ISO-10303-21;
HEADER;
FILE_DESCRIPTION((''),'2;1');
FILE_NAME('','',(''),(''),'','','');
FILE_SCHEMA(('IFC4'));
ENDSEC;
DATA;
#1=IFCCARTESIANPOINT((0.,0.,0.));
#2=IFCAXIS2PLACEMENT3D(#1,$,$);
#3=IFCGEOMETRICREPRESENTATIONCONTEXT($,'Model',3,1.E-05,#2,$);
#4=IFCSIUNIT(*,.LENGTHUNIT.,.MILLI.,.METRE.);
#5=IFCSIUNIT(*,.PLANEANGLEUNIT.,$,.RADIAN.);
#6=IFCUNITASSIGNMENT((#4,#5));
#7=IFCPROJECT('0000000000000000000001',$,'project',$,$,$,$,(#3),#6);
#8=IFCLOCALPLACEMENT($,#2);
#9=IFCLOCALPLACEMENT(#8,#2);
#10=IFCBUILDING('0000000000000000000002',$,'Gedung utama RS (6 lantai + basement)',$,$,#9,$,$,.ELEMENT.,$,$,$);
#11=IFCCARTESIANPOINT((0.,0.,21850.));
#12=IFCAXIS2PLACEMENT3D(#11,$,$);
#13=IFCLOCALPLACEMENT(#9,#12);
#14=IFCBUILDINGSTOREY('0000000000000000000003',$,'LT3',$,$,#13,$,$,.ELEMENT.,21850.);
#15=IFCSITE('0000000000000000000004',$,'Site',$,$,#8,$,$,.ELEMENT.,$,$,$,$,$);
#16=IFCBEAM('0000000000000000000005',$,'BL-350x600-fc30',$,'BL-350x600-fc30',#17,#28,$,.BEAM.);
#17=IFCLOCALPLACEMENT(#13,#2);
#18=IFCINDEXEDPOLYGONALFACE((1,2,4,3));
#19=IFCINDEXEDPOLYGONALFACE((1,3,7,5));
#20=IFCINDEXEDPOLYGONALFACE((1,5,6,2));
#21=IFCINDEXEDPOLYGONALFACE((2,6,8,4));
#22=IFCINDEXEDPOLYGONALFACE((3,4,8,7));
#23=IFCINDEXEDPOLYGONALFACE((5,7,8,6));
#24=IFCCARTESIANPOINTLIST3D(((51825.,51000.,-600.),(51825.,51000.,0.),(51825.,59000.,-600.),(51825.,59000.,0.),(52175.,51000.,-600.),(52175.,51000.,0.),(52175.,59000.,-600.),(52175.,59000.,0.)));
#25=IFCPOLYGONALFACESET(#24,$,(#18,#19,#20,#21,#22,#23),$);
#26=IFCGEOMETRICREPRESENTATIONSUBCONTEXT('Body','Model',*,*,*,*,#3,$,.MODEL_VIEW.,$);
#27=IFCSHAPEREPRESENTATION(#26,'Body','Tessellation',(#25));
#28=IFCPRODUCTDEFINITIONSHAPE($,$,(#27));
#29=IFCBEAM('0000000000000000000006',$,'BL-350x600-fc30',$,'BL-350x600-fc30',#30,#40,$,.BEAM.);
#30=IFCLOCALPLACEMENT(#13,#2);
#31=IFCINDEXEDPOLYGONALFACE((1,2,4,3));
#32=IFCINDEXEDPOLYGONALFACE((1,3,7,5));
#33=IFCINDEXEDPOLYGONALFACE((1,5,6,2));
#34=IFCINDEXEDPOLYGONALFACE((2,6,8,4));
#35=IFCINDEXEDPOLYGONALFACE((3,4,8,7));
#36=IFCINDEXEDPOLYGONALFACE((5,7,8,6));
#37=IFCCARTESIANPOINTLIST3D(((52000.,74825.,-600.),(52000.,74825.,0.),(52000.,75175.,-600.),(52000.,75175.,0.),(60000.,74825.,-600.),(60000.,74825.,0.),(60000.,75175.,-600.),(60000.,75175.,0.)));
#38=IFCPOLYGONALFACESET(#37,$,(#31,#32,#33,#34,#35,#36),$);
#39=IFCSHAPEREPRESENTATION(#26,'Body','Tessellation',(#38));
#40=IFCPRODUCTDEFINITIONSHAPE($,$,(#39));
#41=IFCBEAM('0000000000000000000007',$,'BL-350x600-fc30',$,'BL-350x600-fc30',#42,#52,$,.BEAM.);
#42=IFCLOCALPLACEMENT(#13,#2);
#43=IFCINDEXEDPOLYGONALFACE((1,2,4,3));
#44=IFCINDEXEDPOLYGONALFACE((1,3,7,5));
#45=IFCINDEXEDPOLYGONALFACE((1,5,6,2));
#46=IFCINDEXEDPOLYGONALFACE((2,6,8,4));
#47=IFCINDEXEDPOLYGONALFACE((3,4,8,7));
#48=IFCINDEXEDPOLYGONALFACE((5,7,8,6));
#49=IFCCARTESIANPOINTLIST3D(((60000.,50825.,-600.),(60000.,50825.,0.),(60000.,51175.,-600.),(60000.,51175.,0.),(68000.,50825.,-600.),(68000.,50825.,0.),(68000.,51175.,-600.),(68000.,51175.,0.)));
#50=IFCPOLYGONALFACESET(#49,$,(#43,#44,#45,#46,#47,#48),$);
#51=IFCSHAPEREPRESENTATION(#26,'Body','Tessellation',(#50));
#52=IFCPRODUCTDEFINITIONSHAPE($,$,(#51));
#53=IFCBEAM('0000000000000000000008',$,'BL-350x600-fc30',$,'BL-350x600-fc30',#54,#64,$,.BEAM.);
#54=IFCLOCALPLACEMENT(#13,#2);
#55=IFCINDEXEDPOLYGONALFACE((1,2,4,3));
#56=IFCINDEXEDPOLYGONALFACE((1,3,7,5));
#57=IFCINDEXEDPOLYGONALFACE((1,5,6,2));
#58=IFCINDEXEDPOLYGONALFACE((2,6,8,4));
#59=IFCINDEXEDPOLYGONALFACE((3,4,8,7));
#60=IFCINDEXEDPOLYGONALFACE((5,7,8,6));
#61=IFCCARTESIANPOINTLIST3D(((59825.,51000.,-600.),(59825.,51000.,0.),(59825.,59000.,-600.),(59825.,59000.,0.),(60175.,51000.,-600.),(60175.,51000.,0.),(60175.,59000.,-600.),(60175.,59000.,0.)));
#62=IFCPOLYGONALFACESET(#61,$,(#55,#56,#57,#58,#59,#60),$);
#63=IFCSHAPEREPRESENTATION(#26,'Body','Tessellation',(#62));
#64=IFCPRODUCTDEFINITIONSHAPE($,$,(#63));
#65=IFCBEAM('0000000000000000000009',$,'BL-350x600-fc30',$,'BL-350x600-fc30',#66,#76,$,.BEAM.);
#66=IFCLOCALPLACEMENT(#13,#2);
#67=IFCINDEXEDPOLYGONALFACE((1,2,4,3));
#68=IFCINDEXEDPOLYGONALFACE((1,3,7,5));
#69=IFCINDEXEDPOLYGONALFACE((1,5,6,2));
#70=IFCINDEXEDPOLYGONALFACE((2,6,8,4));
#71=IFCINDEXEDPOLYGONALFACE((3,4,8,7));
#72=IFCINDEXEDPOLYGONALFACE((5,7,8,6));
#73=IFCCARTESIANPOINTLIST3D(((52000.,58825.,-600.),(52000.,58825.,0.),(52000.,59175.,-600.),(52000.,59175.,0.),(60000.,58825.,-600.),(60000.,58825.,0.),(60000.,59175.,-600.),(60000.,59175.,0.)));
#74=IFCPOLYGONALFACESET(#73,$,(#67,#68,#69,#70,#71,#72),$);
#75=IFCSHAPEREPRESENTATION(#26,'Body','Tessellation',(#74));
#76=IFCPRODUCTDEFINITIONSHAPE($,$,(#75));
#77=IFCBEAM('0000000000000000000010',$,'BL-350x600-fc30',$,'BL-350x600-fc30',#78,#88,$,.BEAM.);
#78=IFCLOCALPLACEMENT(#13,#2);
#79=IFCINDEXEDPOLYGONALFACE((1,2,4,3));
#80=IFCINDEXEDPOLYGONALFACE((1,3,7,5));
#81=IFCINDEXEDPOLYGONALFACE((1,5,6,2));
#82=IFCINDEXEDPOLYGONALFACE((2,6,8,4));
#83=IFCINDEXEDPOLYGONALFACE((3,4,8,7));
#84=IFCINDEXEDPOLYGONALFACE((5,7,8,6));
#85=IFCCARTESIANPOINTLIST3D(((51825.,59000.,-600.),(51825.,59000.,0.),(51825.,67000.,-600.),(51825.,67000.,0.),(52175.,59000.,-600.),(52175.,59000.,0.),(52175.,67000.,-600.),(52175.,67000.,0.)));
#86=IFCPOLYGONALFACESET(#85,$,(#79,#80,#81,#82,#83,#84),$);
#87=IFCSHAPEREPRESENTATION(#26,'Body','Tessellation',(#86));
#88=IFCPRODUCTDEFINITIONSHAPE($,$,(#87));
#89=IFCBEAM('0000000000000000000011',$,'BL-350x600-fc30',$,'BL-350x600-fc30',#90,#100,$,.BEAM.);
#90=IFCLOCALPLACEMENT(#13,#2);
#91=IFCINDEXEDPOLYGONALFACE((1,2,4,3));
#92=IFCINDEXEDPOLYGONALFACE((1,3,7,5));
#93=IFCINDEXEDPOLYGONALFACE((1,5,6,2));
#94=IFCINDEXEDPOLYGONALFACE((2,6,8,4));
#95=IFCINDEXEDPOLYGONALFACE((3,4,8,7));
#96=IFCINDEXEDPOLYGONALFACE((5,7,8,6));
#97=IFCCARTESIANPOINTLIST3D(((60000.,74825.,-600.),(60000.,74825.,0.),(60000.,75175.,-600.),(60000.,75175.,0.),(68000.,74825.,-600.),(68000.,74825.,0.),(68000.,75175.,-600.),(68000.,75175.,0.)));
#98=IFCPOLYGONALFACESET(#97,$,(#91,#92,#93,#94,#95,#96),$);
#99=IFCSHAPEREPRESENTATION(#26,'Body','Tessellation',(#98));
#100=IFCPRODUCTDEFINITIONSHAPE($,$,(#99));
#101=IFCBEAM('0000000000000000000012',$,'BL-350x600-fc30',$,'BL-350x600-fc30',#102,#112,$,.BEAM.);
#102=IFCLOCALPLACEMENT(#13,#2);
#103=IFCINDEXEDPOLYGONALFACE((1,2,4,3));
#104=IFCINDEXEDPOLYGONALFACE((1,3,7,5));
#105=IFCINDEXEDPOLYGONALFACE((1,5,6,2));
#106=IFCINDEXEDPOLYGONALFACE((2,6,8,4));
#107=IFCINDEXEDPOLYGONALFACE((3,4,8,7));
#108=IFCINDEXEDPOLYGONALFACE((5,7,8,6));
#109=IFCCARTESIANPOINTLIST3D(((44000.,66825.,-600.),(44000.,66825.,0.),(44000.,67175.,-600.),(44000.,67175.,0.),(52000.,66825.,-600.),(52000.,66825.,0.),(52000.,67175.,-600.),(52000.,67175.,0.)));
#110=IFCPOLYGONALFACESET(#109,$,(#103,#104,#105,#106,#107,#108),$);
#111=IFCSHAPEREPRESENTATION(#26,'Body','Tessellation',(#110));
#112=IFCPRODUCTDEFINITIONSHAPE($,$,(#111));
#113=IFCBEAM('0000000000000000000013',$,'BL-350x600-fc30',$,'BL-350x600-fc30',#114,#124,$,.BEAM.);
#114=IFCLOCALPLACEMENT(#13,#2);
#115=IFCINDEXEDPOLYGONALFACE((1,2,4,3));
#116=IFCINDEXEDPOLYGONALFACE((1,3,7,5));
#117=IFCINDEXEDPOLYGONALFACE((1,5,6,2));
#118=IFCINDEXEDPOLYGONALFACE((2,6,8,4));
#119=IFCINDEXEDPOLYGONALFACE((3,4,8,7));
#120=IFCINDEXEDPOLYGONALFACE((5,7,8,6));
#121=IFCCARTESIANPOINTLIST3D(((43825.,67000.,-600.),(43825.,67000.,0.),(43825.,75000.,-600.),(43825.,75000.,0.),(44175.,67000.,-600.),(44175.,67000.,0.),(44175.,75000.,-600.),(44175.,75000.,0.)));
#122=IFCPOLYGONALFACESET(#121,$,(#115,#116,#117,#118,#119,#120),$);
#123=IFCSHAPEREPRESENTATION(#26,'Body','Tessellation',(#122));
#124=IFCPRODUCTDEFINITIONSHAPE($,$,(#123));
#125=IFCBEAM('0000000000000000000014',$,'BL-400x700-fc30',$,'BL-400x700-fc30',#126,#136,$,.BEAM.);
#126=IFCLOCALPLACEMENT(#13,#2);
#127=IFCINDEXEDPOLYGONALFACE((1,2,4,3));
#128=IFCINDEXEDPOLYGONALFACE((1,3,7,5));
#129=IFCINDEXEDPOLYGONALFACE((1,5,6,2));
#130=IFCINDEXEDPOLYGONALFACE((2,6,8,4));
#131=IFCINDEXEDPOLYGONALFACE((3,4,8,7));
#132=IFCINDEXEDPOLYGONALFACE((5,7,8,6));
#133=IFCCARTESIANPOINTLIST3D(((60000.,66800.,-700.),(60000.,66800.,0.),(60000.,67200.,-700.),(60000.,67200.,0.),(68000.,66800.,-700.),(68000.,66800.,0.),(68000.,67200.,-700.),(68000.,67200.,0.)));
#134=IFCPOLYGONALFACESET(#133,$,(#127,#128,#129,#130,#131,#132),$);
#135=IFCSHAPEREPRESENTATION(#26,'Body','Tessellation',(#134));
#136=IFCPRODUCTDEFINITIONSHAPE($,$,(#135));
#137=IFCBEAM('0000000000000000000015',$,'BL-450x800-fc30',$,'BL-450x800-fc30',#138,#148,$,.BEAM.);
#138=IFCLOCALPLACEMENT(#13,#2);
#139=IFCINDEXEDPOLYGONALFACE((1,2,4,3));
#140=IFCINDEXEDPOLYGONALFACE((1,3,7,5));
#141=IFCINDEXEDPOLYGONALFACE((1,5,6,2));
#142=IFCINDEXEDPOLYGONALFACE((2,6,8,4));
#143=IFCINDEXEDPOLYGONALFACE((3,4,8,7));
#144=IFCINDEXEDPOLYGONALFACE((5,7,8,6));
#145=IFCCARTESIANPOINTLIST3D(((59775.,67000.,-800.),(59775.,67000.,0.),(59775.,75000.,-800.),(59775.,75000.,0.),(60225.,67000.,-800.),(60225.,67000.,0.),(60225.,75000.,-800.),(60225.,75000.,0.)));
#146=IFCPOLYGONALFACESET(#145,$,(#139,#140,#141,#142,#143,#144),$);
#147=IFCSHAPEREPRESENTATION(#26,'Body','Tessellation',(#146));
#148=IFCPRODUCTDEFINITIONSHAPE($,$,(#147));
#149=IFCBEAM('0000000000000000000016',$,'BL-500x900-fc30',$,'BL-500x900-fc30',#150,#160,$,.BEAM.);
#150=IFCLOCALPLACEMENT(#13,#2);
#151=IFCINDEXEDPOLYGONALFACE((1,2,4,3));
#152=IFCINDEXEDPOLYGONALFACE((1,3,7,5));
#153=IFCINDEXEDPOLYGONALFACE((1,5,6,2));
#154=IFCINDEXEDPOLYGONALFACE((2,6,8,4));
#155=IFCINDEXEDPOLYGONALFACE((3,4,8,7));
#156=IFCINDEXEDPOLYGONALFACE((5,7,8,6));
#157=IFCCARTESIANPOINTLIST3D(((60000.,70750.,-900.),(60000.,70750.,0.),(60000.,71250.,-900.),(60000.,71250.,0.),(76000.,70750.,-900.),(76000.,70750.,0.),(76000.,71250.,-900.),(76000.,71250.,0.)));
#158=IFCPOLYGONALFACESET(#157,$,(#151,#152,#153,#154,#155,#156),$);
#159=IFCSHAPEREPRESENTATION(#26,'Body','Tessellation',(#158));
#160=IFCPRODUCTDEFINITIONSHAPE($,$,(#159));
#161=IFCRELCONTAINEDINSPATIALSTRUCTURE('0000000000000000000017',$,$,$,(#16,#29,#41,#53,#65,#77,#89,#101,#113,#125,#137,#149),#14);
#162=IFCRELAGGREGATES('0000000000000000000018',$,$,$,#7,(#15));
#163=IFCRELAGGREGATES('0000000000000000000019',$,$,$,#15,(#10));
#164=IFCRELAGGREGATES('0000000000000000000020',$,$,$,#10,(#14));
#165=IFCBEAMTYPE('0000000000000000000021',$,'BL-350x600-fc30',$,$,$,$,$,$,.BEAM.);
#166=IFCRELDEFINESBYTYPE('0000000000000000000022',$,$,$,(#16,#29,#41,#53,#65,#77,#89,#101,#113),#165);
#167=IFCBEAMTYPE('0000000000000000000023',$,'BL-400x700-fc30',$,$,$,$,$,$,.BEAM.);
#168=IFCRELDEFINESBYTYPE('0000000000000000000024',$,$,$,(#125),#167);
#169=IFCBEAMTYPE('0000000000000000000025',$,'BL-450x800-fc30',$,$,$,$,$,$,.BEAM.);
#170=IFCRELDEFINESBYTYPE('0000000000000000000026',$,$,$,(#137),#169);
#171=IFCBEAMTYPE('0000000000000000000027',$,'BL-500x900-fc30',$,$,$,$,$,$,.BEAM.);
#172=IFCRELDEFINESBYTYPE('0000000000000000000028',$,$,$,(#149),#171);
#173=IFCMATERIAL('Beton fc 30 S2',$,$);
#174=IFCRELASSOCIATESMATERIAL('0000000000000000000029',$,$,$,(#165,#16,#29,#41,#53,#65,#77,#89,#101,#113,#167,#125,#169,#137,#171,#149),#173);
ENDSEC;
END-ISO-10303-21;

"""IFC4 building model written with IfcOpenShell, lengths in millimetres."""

from ifc_helpers import new_model, si_unit, frame, origin, origin_2d, place, context, subcontext, project, spatial, rectangle, extrude, material, material_profile, profile_set, profile_usage, type_object, element, save


model = new_model("IFC4")

# Units and contexts
model_context = context("Model", 3, precision=1e-05, world=origin())
body_context = subcontext(model_context, "Body", "Model", "MODEL_VIEW")
ifc_project = project(units=[si_unit("LENGTHUNIT", "METRE", prefix="MILLI"), si_unit("PLANEANGLEUNIT", "RADIAN")], contexts=[model_context])

# Site, building, storey
site_placement = place(None, origin())
site = spatial("IfcSite", under=ifc_project, at=site_placement, Name="Site", CompositionType="ELEMENT")
building_placement = place(site_placement, origin())
building = spatial("IfcBuilding", under=site, at=building_placement, Name="Gedung utama RS (6 lantai + basement)", CompositionType="ELEMENT")
storey_placement = place(building_placement, frame((0.0, 0.0, 21850.0)))
storey = spatial("IfcBuildingStorey", under=building, at=storey_placement, Name="LT3", CompositionType="ELEMENT", Elevation=21850.0)

# Beams
ifc_material = material(Name="Beton fc 30 S2")
ifc_material_profile_1 = material_profile(ifc_material, rectangle(XDim=350.0, YDim=600.0, at=origin_2d()), Name="BL-350x600-fc30")
ifc_profile_set_1 = profile_set([ifc_material_profile_1], Name="BL-350x600-fc30")
ifc_profile_usage_1 = profile_usage(ifc_profile_set_1, cardinal=8)
beam_type_1 = type_object("IfcBeamType", Name="BL-350x600-fc30", PredefinedType="BEAM", material=ifc_profile_set_1)
beam_1_placement = place(storey_placement, frame((52000.0, 51000.0, -300.0)))
element("IfcBeam", 1, at=beam_1_placement, inside=storey, type_object=beam_type_1, material=ifc_profile_usage_1, Name="BL-350x600-fc30", ObjectType="BL-350x600-fc30", PredefinedType="BEAM", context=body_context, shape_type="SweptSolid", body=[
    extrude(rectangle(XDim=350.0, YDim=600.0, at=origin_2d()), frame((0.0, 0.0, 0.0), z_axis=(0.0, 1.0, 0.0), x_axis=(-1.0, 0.0, 0.0)), (0.0, 0.0, 1.0), 8000.0),
])
for number, where, name in (
    (2, (52000.0, 75000.0, -300.0), "BL-350x600-fc30"),
    (3, (60000.0, 51000.0, -300.0), "BL-350x600-fc30"),
):
    element("IfcBeam", number, at=place(storey_placement, frame(where)), inside=storey, type_object=beam_type_1, material=ifc_profile_usage_1, Name=name, ObjectType="BL-350x600-fc30", PredefinedType="BEAM", context=body_context, shape_type="SweptSolid", body=[
        extrude(rectangle(XDim=350.0, YDim=600.0, at=origin_2d()), frame((0.0, 0.0, 0.0), z_axis=(1.0, 0.0, 0.0), x_axis=(0.0, 1.0, 0.0)), (0.0, 0.0, 1.0), 8000.0),
    ])
beam_2_placement = place(storey_placement, frame((60000.0, 51000.0, -300.0)))
element("IfcBeam", 4, at=beam_2_placement, inside=storey, type_object=beam_type_1, material=ifc_profile_usage_1, Name="BL-350x600-fc30", ObjectType="BL-350x600-fc30", PredefinedType="BEAM", context=body_context, shape_type="SweptSolid", body=[
    extrude(rectangle(XDim=350.0, YDim=600.0, at=origin_2d()), frame((0.0, 0.0, 0.0), z_axis=(0.0, 1.0, 0.0), x_axis=(-1.0, 0.0, 0.0)), (0.0, 0.0, 1.0), 8000.0),
])
beam_3_placement = place(storey_placement, frame((52000.0, 59000.0, -300.0)))
element("IfcBeam", 5, at=beam_3_placement, inside=storey, type_object=beam_type_1, material=ifc_profile_usage_1, Name="BL-350x600-fc30", ObjectType="BL-350x600-fc30", PredefinedType="BEAM", context=body_context, shape_type="SweptSolid", body=[
    extrude(rectangle(XDim=350.0, YDim=600.0, at=origin_2d()), frame((0.0, 0.0, 0.0), z_axis=(1.0, 0.0, 0.0), x_axis=(0.0, 1.0, 0.0)), (0.0, 0.0, 1.0), 8000.0),
])
beam_4_placement = place(storey_placement, frame((52000.0, 59000.0, -300.0)))
element("IfcBeam", 6, at=beam_4_placement, inside=storey, type_object=beam_type_1, material=ifc_profile_usage_1, Name="BL-350x600-fc30", ObjectType="BL-350x600-fc30", PredefinedType="BEAM", context=body_context, shape_type="SweptSolid", body=[
    extrude(rectangle(XDim=350.0, YDim=600.0, at=origin_2d()), frame((0.0, 0.0, 0.0), z_axis=(0.0, 1.0, 0.0), x_axis=(-1.0, 0.0, 0.0)), (0.0, 0.0, 1.0), 8000.0),
])
for number, where, name in (
    (7, (60000.0, 75000.0, -300.0), "BL-350x600-fc30"),
    (8, (44000.0, 67000.0, -300.0), "BL-350x600-fc30"),
):
    element("IfcBeam", number, at=place(storey_placement, frame(where)), inside=storey, type_object=beam_type_1, material=ifc_profile_usage_1, Name=name, ObjectType="BL-350x600-fc30", PredefinedType="BEAM", context=body_context, shape_type="SweptSolid", body=[
        extrude(rectangle(XDim=350.0, YDim=600.0, at=origin_2d()), frame((0.0, 0.0, 0.0), z_axis=(1.0, 0.0, 0.0), x_axis=(0.0, 1.0, 0.0)), (0.0, 0.0, 1.0), 8000.0),
    ])
beam_5_placement = place(storey_placement, frame((44000.0, 67000.0, -300.0)))
element("IfcBeam", 9, at=beam_5_placement, inside=storey, type_object=beam_type_1, material=ifc_profile_usage_1, Name="BL-350x600-fc30", ObjectType="BL-350x600-fc30", PredefinedType="BEAM", context=body_context, shape_type="SweptSolid", body=[
    extrude(rectangle(XDim=350.0, YDim=600.0, at=origin_2d()), frame((0.0, 0.0, 0.0), z_axis=(0.0, 1.0, 0.0), x_axis=(-1.0, 0.0, 0.0)), (0.0, 0.0, 1.0), 8000.0),
])
ifc_material_profile_2 = material_profile(ifc_material, rectangle(XDim=400.0, YDim=700.0, at=origin_2d()), Name="BL-400x700-fc30")
ifc_profile_set_2 = profile_set([ifc_material_profile_2], Name="BL-400x700-fc30")
ifc_profile_usage_2 = profile_usage(ifc_profile_set_2, cardinal=8)
beam_type_2 = type_object("IfcBeamType", Name="BL-400x700-fc30", PredefinedType="BEAM", material=ifc_profile_set_2)
beam_6_placement = place(storey_placement, frame((60000.0, 67000.0, -350.0)))
element("IfcBeam", 10, at=beam_6_placement, inside=storey, type_object=beam_type_2, material=ifc_profile_usage_2, Name="BL-400x700-fc30", ObjectType="BL-400x700-fc30", PredefinedType="BEAM", context=body_context, shape_type="SweptSolid", body=[
    extrude(rectangle(XDim=400.0, YDim=700.0, at=origin_2d()), frame((0.0, 0.0, 0.0), z_axis=(1.0, 0.0, 0.0), x_axis=(0.0, 1.0, 0.0)), (0.0, 0.0, 1.0), 8000.0),
])
ifc_material_profile_3 = material_profile(ifc_material, rectangle(XDim=450.0, YDim=800.0, at=origin_2d()), Name="BL-450x800-fc30")
ifc_profile_set_3 = profile_set([ifc_material_profile_3], Name="BL-450x800-fc30")
ifc_profile_usage_3 = profile_usage(ifc_profile_set_3, cardinal=8)
beam_type_3 = type_object("IfcBeamType", Name="BL-450x800-fc30", PredefinedType="BEAM", material=ifc_profile_set_3)
beam_7_placement = place(storey_placement, frame((60000.0, 67000.0, -400.0)))
element("IfcBeam", 11, at=beam_7_placement, inside=storey, type_object=beam_type_3, material=ifc_profile_usage_3, Name="BL-450x800-fc30", ObjectType="BL-450x800-fc30", PredefinedType="BEAM", context=body_context, shape_type="SweptSolid", body=[
    extrude(rectangle(XDim=450.0, YDim=800.0, at=origin_2d()), frame((0.0, 0.0, 0.0), z_axis=(0.0, 1.0, 0.0), x_axis=(-1.0, 0.0, 0.0)), (0.0, 0.0, 1.0), 8000.0),
])
ifc_material_profile_4 = material_profile(ifc_material, rectangle(XDim=500.0, YDim=900.0, at=origin_2d()), Name="BL-500x900-fc30")
ifc_profile_set_4 = profile_set([ifc_material_profile_4], Name="BL-500x900-fc30")
ifc_profile_usage_4 = profile_usage(ifc_profile_set_4, cardinal=8)
beam_type_4 = type_object("IfcBeamType", Name="BL-500x900-fc30", PredefinedType="BEAM", material=ifc_profile_set_4)
beam_8_placement = place(storey_placement, frame((60000.0, 71000.0, -450.0)))
element("IfcBeam", 12, at=beam_8_placement, inside=storey, type_object=beam_type_4, material=ifc_profile_usage_4, Name="BL-500x900-fc30", ObjectType="BL-500x900-fc30", PredefinedType="BEAM", context=body_context, shape_type="SweptSolid", body=[
    extrude(rectangle(XDim=500.0, YDim=900.0, at=origin_2d()), frame((0.0, 0.0, 0.0), z_axis=(1.0, 0.0, 0.0), x_axis=(0.0, 1.0, 0.0)), (0.0, 0.0, 1.0), 16000.0),
])

save(model, "model.ifc")
